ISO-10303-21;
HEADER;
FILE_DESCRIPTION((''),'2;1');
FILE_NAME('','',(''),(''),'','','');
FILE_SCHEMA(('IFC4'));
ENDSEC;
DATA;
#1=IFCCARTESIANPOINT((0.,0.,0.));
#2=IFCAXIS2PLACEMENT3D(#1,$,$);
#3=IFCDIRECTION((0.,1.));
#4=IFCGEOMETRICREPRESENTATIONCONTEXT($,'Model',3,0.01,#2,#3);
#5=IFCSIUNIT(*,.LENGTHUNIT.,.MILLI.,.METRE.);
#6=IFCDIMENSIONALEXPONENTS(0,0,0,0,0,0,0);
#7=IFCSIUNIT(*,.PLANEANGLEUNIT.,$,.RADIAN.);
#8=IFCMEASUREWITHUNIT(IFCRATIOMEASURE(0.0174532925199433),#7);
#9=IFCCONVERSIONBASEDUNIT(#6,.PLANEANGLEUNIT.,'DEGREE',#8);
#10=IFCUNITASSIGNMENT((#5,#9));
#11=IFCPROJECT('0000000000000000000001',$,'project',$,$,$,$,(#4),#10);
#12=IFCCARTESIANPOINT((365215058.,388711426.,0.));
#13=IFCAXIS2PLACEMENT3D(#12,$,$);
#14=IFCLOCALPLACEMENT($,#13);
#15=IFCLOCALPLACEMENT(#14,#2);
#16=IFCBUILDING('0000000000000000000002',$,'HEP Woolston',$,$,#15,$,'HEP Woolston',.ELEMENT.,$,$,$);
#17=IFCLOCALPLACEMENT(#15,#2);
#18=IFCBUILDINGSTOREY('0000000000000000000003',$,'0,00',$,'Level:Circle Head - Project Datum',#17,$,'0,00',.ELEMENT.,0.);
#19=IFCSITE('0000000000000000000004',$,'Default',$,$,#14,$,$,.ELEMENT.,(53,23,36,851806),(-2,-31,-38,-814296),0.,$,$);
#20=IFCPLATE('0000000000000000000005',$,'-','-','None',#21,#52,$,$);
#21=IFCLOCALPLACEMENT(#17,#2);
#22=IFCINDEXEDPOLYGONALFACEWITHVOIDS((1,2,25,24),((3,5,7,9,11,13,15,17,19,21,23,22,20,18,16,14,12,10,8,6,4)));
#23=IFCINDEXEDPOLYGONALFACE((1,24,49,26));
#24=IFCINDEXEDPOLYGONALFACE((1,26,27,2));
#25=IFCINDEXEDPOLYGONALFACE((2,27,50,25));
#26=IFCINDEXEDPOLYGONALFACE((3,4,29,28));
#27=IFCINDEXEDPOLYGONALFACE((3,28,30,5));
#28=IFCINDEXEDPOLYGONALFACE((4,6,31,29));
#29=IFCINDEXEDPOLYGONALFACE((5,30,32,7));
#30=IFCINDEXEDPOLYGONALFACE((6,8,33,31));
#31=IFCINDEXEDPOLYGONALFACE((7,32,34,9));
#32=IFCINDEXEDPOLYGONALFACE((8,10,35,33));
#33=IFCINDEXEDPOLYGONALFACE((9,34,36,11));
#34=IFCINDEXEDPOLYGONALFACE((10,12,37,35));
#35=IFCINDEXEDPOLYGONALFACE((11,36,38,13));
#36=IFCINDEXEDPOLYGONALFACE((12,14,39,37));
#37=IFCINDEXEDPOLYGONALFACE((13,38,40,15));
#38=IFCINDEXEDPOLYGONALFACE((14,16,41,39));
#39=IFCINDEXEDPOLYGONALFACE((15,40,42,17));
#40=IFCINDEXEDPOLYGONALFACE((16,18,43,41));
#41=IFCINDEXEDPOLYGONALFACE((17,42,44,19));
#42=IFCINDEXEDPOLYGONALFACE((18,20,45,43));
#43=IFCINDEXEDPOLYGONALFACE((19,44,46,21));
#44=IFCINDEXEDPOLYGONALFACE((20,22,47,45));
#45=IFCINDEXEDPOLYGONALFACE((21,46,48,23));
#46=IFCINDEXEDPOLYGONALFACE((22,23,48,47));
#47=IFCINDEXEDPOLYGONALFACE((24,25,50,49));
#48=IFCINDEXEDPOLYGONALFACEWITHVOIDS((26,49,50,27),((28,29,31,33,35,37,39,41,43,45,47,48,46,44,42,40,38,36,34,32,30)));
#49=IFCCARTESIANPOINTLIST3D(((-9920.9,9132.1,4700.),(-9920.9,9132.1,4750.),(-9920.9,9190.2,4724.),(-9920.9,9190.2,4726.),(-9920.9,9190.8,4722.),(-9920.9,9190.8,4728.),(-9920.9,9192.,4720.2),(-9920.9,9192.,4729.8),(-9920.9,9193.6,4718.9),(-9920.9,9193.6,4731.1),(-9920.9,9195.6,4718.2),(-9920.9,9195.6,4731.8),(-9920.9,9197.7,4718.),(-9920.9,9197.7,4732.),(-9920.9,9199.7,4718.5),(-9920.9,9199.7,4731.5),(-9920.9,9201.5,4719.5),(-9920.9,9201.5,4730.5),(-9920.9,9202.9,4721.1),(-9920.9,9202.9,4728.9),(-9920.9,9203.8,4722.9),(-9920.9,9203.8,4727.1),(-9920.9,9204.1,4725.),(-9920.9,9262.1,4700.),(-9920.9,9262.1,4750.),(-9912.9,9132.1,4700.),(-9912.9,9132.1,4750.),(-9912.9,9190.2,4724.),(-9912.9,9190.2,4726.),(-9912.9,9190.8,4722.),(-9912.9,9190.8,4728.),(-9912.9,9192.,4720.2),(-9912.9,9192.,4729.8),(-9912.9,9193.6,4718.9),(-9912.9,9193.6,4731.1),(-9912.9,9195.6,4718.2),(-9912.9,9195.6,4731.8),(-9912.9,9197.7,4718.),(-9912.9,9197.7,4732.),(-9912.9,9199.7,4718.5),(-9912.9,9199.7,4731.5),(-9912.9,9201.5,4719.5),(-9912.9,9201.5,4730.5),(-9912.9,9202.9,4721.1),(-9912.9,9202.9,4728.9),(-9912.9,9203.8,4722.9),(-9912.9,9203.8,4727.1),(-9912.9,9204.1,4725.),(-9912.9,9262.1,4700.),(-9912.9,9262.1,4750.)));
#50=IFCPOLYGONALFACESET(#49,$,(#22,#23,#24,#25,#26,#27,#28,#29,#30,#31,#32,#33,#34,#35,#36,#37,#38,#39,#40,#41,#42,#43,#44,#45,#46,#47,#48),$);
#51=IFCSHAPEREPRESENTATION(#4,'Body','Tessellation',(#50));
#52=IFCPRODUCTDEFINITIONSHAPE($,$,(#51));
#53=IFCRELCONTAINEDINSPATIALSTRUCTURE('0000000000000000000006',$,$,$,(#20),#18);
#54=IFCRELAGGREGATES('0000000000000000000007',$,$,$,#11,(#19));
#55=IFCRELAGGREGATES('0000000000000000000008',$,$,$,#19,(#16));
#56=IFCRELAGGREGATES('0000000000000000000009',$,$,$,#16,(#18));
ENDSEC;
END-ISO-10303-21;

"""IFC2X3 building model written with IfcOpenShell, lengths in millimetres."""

from ifc_helpers import new_model, entity, si_unit, converted_unit, direction, frame, origin, origin_with_axes, origin_2d_with_axis, place, context, project, spatial, polyline, circle, outline, extrude, element, save


model = new_model("IFC2X3")

# Units and contexts
model_context = context("Model", 3, precision=0.01, world=origin(), true_north=direction((0.0, 1.0)))
ifc_project = project(units=[si_unit("LENGTHUNIT", "METRE", prefix="MILLI"), converted_unit("PLANEANGLEUNIT", "DEGREE", entity("IfcRatioMeasure", 0.0174532925199433), si_unit("PLANEANGLEUNIT", "RADIAN"), dimensions=[0, 0, 0, 0, 0, 0, 0])], contexts=[model_context])

# Site, building, storey
site_placement = place(None, frame((365215058.0, 388711426.0, 0.0)))
site = spatial("IfcSite", under=ifc_project, at=site_placement, Name="Default", CompositionType="ELEMENT", RefLatitude=(53, 23, 36, 851806), RefLongitude=(-2, -31, -38, -814296), RefElevation=0.0)
building_placement = place(site_placement, origin())
building = spatial("IfcBuilding", under=site, at=building_placement, Name="HEP Woolston", LongName="HEP Woolston", CompositionType="ELEMENT")
storey_placement = place(building_placement, origin())
storey = spatial("IfcBuildingStorey", under=building, at=storey_placement, Name="0,00", ObjectType="Level:Circle Head - Project Datum", LongName="0,00", CompositionType="ELEMENT", Elevation=0.0)

# Plate, opening
plate_1_placement = place(storey_placement, frame((-9920.9, 9132.1, 4750.0), z_axis=(1.0, 0.0, 0.0), x_axis=(0.0, 1.0, 0.0)))
plate_1 = element("IfcPlate", 1, at=plate_1_placement, inside=storey, Name="-", Description="-", ObjectType="None", context=model_context, shape_type="SweptSolid", body=[
    extrude(outline(polyline([(0.0, -50.0), (130.0, -50.0), (130.0, 0.0), (0.0, 0.0), (0.0, -50.0)])), origin_with_axes(), (0.0, 0.0, 1.0), 8.0),
])
opening_1_placement = place(plate_1_placement, frame((65.0, -25.0, 8.5), z_axis=(0.0, 0.0, -1.0), x_axis=(1.0, 0.0, 0.0)))
element("IfcOpeningElement", 2, at=opening_1_placement, cuts=plate_1, ObjectType="Opening", context=model_context, shape_type="SweptSolid", body=[
    extrude(circle(Radius=7.0, at=origin_2d_with_axis()), origin(), (0.0, 0.0, 1.0), 9.0),
])

save(model, "model.ifc")
